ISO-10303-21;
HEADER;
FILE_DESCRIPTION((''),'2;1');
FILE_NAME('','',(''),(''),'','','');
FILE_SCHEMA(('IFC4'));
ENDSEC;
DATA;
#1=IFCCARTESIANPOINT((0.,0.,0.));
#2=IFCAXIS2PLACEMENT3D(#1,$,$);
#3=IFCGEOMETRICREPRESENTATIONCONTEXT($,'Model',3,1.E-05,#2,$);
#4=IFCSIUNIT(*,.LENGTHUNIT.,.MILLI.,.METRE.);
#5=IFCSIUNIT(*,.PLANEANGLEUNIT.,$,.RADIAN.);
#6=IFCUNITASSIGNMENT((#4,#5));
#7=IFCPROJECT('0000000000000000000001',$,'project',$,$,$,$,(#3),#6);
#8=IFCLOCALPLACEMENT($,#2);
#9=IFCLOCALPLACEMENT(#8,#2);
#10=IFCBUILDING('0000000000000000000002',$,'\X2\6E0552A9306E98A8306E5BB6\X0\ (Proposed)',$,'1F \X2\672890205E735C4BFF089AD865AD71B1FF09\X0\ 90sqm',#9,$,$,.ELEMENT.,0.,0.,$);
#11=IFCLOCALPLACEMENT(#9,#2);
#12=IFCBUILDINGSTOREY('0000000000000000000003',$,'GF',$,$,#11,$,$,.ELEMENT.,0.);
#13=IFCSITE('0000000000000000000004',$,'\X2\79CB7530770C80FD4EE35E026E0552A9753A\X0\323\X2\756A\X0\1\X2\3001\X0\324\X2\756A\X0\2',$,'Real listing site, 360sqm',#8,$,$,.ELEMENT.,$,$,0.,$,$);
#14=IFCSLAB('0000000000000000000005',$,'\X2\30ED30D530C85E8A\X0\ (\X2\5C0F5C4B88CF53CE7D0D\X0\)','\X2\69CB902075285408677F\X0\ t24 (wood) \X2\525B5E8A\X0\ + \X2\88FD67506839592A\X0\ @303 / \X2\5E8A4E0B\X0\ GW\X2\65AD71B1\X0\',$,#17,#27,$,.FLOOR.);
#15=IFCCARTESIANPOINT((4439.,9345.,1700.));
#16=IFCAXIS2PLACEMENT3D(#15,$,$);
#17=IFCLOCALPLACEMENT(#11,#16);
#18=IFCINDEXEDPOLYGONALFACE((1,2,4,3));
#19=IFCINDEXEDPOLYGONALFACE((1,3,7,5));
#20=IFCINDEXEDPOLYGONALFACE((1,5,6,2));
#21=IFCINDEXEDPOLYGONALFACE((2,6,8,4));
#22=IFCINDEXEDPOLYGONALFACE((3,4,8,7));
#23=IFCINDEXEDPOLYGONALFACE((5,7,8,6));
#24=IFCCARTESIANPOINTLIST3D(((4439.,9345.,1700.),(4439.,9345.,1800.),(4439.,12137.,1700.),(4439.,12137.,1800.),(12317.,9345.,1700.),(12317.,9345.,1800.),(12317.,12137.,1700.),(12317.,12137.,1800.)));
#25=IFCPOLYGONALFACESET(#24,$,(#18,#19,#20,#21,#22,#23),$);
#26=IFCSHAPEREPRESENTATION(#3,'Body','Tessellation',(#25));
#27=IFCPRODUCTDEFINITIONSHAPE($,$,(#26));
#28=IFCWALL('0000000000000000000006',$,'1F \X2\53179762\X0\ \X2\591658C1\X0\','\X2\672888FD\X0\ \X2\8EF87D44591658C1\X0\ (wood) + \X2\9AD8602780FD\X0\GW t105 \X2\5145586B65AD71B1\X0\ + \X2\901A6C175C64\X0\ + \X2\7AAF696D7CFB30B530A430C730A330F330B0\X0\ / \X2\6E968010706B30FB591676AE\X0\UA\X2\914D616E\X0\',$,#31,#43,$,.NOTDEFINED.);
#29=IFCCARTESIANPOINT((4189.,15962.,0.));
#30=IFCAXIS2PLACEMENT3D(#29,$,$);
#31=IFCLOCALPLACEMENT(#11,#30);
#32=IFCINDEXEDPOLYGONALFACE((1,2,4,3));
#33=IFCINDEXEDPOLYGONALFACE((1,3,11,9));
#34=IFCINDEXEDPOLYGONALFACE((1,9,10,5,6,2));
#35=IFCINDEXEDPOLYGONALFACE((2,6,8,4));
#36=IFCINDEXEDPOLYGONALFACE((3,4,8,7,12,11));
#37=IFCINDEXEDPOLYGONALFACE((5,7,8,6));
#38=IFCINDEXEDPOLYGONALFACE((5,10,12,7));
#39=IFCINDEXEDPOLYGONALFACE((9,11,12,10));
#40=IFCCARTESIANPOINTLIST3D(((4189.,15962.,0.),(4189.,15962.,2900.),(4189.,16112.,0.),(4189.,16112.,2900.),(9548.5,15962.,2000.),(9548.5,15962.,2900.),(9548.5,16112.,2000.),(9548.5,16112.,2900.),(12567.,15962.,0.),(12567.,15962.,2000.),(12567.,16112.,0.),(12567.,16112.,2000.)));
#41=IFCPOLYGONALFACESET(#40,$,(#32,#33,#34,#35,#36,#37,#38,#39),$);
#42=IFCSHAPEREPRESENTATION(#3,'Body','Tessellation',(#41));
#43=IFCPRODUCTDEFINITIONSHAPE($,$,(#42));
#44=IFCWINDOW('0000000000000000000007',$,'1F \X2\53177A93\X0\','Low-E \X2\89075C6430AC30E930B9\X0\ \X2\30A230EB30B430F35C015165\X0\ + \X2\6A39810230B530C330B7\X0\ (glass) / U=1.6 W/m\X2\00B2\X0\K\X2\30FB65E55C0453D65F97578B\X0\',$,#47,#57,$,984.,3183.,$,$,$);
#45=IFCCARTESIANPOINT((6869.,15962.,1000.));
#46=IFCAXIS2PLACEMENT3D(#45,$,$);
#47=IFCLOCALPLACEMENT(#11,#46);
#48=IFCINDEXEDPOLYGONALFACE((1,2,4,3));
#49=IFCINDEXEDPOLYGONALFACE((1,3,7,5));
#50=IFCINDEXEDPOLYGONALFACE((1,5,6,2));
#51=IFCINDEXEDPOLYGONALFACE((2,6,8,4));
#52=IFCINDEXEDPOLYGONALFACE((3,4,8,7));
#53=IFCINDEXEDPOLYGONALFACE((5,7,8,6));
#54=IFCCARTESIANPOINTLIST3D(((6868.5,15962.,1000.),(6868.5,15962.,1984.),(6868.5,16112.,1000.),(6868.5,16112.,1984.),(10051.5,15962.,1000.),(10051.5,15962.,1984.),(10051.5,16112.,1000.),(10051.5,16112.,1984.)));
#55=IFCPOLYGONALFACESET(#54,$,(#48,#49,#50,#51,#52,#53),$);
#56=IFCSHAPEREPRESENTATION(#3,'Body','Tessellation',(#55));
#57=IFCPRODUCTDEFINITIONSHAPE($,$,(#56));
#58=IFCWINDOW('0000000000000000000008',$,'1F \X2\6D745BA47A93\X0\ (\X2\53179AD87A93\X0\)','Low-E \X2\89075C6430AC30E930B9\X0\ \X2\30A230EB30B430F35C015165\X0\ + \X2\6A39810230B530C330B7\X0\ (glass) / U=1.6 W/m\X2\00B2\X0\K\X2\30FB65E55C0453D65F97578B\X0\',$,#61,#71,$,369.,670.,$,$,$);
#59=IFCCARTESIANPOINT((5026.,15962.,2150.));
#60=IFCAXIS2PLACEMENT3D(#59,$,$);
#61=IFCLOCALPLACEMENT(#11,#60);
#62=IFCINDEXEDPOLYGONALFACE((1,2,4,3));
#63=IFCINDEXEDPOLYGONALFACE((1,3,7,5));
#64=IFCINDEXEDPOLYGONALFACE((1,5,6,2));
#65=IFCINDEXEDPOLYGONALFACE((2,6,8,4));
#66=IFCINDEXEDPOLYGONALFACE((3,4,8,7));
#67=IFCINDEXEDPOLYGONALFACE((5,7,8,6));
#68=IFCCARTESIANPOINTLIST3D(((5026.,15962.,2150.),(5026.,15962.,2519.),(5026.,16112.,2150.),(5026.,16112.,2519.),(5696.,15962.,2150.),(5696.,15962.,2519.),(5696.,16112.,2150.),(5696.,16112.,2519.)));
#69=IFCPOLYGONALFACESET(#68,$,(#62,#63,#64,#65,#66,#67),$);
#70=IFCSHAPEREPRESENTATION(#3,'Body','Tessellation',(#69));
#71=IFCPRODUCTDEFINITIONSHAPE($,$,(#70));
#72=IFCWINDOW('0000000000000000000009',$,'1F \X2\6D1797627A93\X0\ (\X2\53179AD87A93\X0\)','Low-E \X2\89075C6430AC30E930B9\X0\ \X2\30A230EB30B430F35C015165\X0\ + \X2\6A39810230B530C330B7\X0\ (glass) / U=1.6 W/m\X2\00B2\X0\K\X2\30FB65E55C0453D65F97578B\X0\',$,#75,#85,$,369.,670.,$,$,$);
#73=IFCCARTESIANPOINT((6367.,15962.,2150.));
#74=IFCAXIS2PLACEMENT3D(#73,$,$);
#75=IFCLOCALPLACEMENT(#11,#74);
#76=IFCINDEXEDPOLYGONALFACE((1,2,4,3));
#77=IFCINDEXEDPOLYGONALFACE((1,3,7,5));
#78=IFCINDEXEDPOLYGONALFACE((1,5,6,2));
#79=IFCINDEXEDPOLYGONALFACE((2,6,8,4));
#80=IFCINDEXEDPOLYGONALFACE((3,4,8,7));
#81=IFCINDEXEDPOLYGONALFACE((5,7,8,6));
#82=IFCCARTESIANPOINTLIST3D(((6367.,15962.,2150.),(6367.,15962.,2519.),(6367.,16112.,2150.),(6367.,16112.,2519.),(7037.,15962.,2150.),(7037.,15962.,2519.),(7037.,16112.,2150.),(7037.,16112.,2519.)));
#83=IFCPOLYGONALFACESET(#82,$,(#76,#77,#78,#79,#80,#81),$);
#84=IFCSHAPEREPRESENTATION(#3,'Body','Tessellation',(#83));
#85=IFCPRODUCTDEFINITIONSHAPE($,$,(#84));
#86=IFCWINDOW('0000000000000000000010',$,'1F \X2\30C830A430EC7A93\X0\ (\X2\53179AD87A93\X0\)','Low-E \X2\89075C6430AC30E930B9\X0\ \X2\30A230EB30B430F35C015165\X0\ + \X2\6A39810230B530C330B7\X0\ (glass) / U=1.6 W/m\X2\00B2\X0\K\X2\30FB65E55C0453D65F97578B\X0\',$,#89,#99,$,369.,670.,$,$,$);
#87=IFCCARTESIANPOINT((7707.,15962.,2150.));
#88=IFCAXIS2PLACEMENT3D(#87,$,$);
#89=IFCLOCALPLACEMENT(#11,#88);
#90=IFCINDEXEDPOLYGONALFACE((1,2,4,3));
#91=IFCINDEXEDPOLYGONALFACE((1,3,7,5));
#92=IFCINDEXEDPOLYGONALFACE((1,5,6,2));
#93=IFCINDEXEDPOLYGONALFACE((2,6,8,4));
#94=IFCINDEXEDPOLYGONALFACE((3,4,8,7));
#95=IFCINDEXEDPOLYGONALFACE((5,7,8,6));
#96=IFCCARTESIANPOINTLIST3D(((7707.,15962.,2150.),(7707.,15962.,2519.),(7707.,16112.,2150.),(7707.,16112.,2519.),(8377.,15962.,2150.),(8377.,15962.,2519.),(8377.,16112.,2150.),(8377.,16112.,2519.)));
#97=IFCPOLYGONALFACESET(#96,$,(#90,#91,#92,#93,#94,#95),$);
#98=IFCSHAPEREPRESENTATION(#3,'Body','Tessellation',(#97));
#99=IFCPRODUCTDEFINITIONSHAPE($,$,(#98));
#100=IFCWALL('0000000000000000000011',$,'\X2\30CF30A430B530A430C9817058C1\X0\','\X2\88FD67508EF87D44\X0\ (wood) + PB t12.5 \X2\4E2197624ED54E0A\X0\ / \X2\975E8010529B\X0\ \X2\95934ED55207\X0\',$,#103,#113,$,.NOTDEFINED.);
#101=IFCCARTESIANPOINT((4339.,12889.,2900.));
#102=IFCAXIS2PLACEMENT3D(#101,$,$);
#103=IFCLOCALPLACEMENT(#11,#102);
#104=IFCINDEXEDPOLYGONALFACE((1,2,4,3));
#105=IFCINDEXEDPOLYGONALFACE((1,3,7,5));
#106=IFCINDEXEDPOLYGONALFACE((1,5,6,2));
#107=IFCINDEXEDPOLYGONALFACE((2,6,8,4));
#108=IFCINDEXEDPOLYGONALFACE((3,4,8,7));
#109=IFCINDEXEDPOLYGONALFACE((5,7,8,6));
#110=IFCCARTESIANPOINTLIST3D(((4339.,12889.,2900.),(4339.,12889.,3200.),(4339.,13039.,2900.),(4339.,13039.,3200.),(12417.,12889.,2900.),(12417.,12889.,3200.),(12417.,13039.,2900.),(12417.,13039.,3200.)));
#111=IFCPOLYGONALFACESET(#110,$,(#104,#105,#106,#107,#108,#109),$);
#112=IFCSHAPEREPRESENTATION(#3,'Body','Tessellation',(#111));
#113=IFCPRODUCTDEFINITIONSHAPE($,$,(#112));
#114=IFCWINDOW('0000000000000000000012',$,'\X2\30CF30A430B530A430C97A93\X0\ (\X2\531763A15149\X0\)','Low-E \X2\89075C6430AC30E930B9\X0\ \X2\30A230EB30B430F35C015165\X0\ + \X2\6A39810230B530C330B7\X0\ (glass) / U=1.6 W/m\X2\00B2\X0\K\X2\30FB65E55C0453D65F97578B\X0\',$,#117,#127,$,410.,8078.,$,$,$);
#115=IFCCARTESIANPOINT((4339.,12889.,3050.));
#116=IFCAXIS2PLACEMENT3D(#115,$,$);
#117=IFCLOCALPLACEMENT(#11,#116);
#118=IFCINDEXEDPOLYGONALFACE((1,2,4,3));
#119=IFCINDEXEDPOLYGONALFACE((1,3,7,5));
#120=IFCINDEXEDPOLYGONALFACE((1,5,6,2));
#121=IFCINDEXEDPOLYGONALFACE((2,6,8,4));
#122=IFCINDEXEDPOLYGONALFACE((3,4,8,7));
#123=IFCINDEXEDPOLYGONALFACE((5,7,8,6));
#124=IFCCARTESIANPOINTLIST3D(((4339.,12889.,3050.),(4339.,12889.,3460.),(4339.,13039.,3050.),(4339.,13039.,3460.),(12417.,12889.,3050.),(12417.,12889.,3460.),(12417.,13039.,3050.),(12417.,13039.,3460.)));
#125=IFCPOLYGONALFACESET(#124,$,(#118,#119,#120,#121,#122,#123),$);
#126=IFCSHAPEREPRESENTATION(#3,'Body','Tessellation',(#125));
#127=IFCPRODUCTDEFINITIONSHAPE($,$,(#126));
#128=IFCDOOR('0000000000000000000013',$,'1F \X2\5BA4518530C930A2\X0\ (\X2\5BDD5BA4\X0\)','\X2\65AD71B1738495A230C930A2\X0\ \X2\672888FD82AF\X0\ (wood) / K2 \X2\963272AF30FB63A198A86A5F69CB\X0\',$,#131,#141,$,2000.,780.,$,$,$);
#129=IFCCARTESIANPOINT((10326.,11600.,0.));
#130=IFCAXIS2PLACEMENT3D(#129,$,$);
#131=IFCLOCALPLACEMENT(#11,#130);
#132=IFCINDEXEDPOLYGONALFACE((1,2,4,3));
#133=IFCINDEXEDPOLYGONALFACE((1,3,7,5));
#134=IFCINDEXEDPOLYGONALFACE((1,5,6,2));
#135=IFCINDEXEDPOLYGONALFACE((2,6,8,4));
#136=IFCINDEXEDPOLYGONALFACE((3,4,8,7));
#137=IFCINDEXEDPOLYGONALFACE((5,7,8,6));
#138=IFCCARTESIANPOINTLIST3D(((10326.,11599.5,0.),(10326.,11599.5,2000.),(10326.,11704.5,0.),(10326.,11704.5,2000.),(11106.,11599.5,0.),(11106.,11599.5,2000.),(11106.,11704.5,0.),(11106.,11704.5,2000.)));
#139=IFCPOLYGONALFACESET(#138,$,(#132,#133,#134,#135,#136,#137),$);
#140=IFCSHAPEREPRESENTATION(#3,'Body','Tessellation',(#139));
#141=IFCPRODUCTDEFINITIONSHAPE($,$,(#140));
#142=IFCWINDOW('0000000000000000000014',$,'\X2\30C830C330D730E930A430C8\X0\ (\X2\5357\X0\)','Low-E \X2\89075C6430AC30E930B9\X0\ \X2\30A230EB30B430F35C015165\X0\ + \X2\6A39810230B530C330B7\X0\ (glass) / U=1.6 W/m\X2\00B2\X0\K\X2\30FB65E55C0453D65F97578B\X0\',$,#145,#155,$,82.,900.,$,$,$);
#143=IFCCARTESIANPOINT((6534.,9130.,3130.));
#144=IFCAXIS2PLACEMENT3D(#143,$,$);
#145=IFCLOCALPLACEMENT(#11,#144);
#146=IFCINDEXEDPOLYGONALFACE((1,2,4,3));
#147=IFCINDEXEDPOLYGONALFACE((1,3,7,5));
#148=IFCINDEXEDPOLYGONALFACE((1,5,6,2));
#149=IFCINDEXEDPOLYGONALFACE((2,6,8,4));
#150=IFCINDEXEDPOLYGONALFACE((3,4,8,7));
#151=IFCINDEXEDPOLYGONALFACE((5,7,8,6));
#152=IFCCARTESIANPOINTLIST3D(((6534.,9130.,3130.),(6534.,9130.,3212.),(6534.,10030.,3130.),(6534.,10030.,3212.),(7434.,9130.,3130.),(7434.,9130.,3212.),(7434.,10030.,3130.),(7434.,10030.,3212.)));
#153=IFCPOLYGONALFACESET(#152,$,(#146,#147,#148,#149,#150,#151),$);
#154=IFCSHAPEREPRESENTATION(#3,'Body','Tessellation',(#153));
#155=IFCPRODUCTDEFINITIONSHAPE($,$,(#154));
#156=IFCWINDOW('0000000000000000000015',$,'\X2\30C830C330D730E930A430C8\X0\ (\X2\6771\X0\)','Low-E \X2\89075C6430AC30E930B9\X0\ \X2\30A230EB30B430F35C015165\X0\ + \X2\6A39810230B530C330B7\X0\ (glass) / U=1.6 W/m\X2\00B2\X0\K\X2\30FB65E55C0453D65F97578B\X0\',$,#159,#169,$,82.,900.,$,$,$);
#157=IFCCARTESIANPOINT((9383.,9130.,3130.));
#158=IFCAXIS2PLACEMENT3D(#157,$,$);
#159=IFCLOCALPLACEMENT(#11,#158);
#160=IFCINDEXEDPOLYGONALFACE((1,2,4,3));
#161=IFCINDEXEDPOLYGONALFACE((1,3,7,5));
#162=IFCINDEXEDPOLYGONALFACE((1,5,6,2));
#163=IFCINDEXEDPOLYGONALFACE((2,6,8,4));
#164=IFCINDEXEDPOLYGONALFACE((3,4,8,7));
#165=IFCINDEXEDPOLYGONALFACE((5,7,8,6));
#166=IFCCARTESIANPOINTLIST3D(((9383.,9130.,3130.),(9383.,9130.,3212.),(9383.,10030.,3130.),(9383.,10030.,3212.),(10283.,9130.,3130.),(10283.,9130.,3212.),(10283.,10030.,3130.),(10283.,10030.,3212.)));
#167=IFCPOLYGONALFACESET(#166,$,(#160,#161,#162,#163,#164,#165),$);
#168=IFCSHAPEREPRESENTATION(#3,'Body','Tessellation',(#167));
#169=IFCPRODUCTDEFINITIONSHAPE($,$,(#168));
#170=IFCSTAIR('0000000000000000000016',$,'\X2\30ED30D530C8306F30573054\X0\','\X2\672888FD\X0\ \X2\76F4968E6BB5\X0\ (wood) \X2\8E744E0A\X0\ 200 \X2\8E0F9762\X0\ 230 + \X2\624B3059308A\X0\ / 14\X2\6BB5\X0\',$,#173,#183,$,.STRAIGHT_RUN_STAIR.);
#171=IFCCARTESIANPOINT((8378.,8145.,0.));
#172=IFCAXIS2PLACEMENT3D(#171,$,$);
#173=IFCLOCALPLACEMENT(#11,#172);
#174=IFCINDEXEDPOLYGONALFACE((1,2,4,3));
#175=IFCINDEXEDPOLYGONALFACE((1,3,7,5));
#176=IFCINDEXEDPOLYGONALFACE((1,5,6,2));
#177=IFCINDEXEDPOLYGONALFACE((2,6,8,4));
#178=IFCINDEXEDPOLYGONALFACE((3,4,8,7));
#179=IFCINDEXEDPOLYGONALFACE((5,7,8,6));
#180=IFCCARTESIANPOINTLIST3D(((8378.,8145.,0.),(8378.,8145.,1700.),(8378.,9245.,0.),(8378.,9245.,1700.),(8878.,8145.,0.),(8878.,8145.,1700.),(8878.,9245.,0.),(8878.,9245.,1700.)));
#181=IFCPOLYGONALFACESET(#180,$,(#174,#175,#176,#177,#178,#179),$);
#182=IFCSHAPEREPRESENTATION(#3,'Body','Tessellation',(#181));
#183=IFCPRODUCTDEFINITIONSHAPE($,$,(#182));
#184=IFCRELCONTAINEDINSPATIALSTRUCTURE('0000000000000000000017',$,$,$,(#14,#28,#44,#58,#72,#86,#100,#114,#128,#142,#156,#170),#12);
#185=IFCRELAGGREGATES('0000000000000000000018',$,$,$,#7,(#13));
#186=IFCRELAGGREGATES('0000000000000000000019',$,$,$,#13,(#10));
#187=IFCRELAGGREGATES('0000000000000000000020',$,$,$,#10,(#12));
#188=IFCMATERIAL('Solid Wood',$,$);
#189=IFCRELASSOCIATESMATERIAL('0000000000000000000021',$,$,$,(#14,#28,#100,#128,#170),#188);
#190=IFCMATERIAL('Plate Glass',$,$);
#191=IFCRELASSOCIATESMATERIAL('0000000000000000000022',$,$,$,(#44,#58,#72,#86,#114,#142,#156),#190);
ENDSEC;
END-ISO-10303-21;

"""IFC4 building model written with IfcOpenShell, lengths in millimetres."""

from ifc_helpers import new_model, si_unit, frame, frame_2d, origin, place, context, project, spatial, rectangle, extrude, material, element, fill, save


model = new_model("IFC4")

# Units and contexts
model_context = context("Model", 3, precision=1e-05, world=origin())
ifc_project = project(units=[si_unit("LENGTHUNIT", "METRE", prefix="MILLI"), si_unit("PLANEANGLEUNIT", "RADIAN")], contexts=[model_context])

# Site, building, storey
site_placement = place(None, origin())
site = spatial("IfcSite", under=ifc_project, at=site_placement, Name="秋田県能代市清助町323番1、324番2", ObjectType="Real listing site, 360sqm", CompositionType="ELEMENT", RefElevation=0.0)
building_placement = place(site_placement, origin())
building = spatial("IfcBuilding", under=site, at=building_placement, Name="清助の風の家 (Proposed)", ObjectType="1F 木造平屋（高断熱） 90sqm", CompositionType="ELEMENT", ElevationOfRefHeight=0.0, ElevationOfTerrain=0.0)
storey_placement = place(building_placement, origin())
storey = spatial("IfcBuildingStorey", under=building, at=storey_placement, Name="GF", CompositionType="ELEMENT", Elevation=0.0)

# Slab
ifc_material_1 = material(Name="Solid Wood")
slab_placement = place(storey_placement, frame((4439.0, 9345.0, 1700.0)))
element("IfcSlab", 1, at=slab_placement, inside=storey, material=ifc_material_1, Name="ロフト床 (小屋裏収納)", Description="構造用合板 t24 (wood) 剛床 + 製材根太 @303 / 床下 GW断熱", PredefinedType="FLOOR", context=model_context, shape_type="SweptSolid", body=[
    extrude(rectangle(XDim=7878.0, YDim=2792.0, at=frame_2d((3939.0, 1396.0))), frame((4439.0, 9345.0, 1700.0)), (0.0, 0.0, 1.0), 100.0),
])

# Wall, openings, windows
wall_1_placement = place(storey_placement, frame((4189.0, 15962.0, 0.0)))
wall_1 = element("IfcWall", 2, at=wall_1_placement, inside=storey, material=ifc_material_1, Name="1F 北面 外壁", Description="木製 軸組外壁 (wood) + 高性能GW t105 充填断熱 + 通気層 + 窯業系サイディング / 準耐火・外皮UA配慮", PredefinedType="NOTDEFINED", context=model_context, shape_type="SweptSolid", body=[
    extrude(rectangle(XDim=8378.0, YDim=150.0, at=frame_2d((4189.0, 75.0))), frame((4189.0, 15962.0, 0.0)), (0.0, 0.0, 1.0), 2900.0),
])
opening_1_placement = place(storey_placement, frame((6869.0, 15962.0, 1000.0)))
opening_1 = element("IfcOpeningElement", 3, at=opening_1_placement, cuts=wall_1, PredefinedType="NOTDEFINED", context=model_context, shape_type="SweptSolid", body=[
    extrude(rectangle(XDim=3183.0, YDim=150.0, at=frame_2d((1591.0, 75.0))), frame((6869.0, 15962.0, 1000.0)), (0.0, 0.0, 1.0), 984.0),
])
opening_2_placement = place(storey_placement, frame((5026.0, 15962.0, 2150.0)))
opening_2 = element("IfcOpeningElement", 4, at=opening_2_placement, cuts=wall_1, PredefinedType="NOTDEFINED", context=model_context, shape_type="SweptSolid", body=[
    extrude(rectangle(XDim=670.0, YDim=150.0, at=frame_2d((335.0, 75.0))), frame((5026.0, 15962.0, 2150.0)), (0.0, 0.0, 1.0), 369.0),
])
opening_3_placement = place(storey_placement, frame((6367.0, 15962.0, 2150.0)))
opening_3 = element("IfcOpeningElement", 5, at=opening_3_placement, cuts=wall_1, PredefinedType="NOTDEFINED", context=model_context, shape_type="SweptSolid", body=[
    extrude(rectangle(XDim=670.0, YDim=150.0, at=frame_2d((335.0, 75.0))), frame((6367.0, 15962.0, 2150.0)), (0.0, 0.0, 1.0), 369.0),
])
opening_4_placement = place(storey_placement, frame((7707.0, 15962.0, 2150.0)))
opening_4 = element("IfcOpeningElement", 6, at=opening_4_placement, cuts=wall_1, PredefinedType="NOTDEFINED", context=model_context, shape_type="SweptSolid", body=[
    extrude(rectangle(XDim=670.0, YDim=150.0, at=frame_2d((335.0, 75.0))), frame((7707.0, 15962.0, 2150.0)), (0.0, 0.0, 1.0), 369.0),
])
ifc_material_2 = material(Name="Plate Glass")
window_1_placement = place(storey_placement, frame((6869.0, 15962.0, 1000.0)))
window_1 = element("IfcWindow", 7, at=window_1_placement, inside=storey, material=ifc_material_2, Name="1F 北窓", Description="Low-E 複層ガラス アルゴン封入 + 樹脂サッシ (glass) / U=1.6 W/m²K・日射取得型", OverallHeight=984.0, OverallWidth=3183.0, context=model_context, shape_type="SweptSolid", body=[
    extrude(rectangle(XDim=3183.0, YDim=150.0, at=frame_2d((1591.0, 75.0))), frame((6869.0, 15962.0, 1000.0)), (0.0, 0.0, 1.0), 984.0),
])
fill(opening_1, window_1)
window_2_placement = place(storey_placement, frame((5026.0, 15962.0, 2150.0)))
window_2 = element("IfcWindow", 8, at=window_2_placement, inside=storey, material=ifc_material_2, Name="1F 浴室窓 (北高窓)", Description="Low-E 複層ガラス アルゴン封入 + 樹脂サッシ (glass) / U=1.6 W/m²K・日射取得型", OverallHeight=369.0, OverallWidth=670.0, context=model_context, shape_type="SweptSolid", body=[
    extrude(rectangle(XDim=670.0, YDim=150.0, at=frame_2d((335.0, 75.0))), frame((5026.0, 15962.0, 2150.0)), (0.0, 0.0, 1.0), 369.0),
])
fill(opening_2, window_2)
window_3_placement = place(storey_placement, frame((6367.0, 15962.0, 2150.0)))
window_3 = element("IfcWindow", 9, at=window_3_placement, inside=storey, material=ifc_material_2, Name="1F 洗面窓 (北高窓)", Description="Low-E 複層ガラス アルゴン封入 + 樹脂サッシ (glass) / U=1.6 W/m²K・日射取得型", OverallHeight=369.0, OverallWidth=670.0, context=model_context, shape_type="SweptSolid", body=[
    extrude(rectangle(XDim=670.0, YDim=150.0, at=frame_2d((335.0, 75.0))), frame((6367.0, 15962.0, 2150.0)), (0.0, 0.0, 1.0), 369.0),
])
fill(opening_3, window_3)
window_4_placement = place(storey_placement, frame((7707.0, 15962.0, 2150.0)))
window_4 = element("IfcWindow", 10, at=window_4_placement, inside=storey, material=ifc_material_2, Name="1F トイレ窓 (北高窓)", Description="Low-E 複層ガラス アルゴン封入 + 樹脂サッシ (glass) / U=1.6 W/m²K・日射取得型", OverallHeight=369.0, OverallWidth=670.0, context=model_context, shape_type="SweptSolid", body=[
    extrude(rectangle(XDim=670.0, YDim=150.0, at=frame_2d((335.0, 75.0))), frame((7707.0, 15962.0, 2150.0)), (0.0, 0.0, 1.0), 369.0),
])
fill(opening_4, window_4)

# Wall, opening, window
wall_2_placement = place(storey_placement, frame((4339.0, 12889.0, 2900.0)))
wall_2 = element("IfcWall", 11, at=wall_2_placement, inside=storey, material=ifc_material_1, Name="ハイサイド腰壁", Description="製材軸組 (wood) + PB t12.5 両面仕上 / 非耐力 間仕切", PredefinedType="NOTDEFINED", context=model_context, shape_type="SweptSolid", body=[
    extrude(rectangle(XDim=8078.0, YDim=150.0, at=frame_2d((4039.0, 75.0))), frame((4339.0, 12889.0, 2900.0)), (0.0, 0.0, 1.0), 700.0),
])
opening_5_placement = place(storey_placement, frame((4339.0, 12889.0, 3050.0)))
opening_5 = element("IfcOpeningElement", 12, at=opening_5_placement, cuts=wall_2, PredefinedType="NOTDEFINED", context=model_context, shape_type="SweptSolid", body=[
    extrude(rectangle(XDim=8078.0, YDim=150.0, at=frame_2d((4039.0, 75.0))), frame((4339.0, 12889.0, 3050.0)), (0.0, 0.0, 1.0), 410.0),
])
window_5_placement = place(storey_placement, frame((4339.0, 12889.0, 3050.0)))
window_5 = element("IfcWindow", 13, at=window_5_placement, inside=storey, material=ifc_material_2, Name="ハイサイド窓 (北採光)", Description="Low-E 複層ガラス アルゴン封入 + 樹脂サッシ (glass) / U=1.6 W/m²K・日射取得型", OverallHeight=410.0, OverallWidth=8078.0, context=model_context, shape_type="SweptSolid", body=[
    extrude(rectangle(XDim=8078.0, YDim=150.0, at=frame_2d((4039.0, 75.0))), frame((4339.0, 12889.0, 3050.0)), (0.0, 0.0, 1.0), 410.0),
])
fill(opening_5, window_5)

# Door
door_1_placement = place(storey_placement, frame((10326.0, 11600.0, 0.0)))
element("IfcDoor", 14, at=door_1_placement, inside=storey, material=ifc_material_1, Name="1F 室内ドア (寝室)", Description="断熱玄関ドア 木製芯 (wood) / K2 防犯・採風機構", OverallHeight=2000.0, OverallWidth=780.0, context=model_context, shape_type="SweptSolid", body=[
    extrude(rectangle(XDim=780.0, YDim=105.0, at=frame_2d((390.0, 52.0))), frame((10326.0, 11600.0, 0.0)), (0.0, 0.0, 1.0), 2000.0),
])

# Windows
window_6_placement = place(storey_placement, frame((6534.0, 9130.0, 3130.0)))
element("IfcWindow", 15, at=window_6_placement, inside=storey, material=ifc_material_2, Name="トップライト (南)", Description="Low-E 複層ガラス アルゴン封入 + 樹脂サッシ (glass) / U=1.6 W/m²K・日射取得型", OverallHeight=82.0, OverallWidth=900.0, context=model_context, shape_type="SweptSolid", body=[
    extrude(rectangle(XDim=900.0, YDim=900.0, at=frame_2d((450.0, 450.0))), frame((6534.0, 9130.0, 3130.0)), (0.0, 0.0, 1.0), 82.0),
])
window_7_placement = place(storey_placement, frame((9383.0, 9130.0, 3130.0)))
element("IfcWindow", 16, at=window_7_placement, inside=storey, material=ifc_material_2, Name="トップライト (東)", Description="Low-E 複層ガラス アルゴン封入 + 樹脂サッシ (glass) / U=1.6 W/m²K・日射取得型", OverallHeight=82.0, OverallWidth=900.0, context=model_context, shape_type="SweptSolid", body=[
    extrude(rectangle(XDim=900.0, YDim=900.0, at=frame_2d((450.0, 450.0))), frame((9383.0, 9130.0, 3130.0)), (0.0, 0.0, 1.0), 82.0),
])

# Stair
stair_placement = place(storey_placement, frame((8378.0, 8145.0, 0.0)))
element("IfcStair", 17, at=stair_placement, inside=storey, material=ifc_material_1, Name="ロフトはしご", Description="木製 直階段 (wood) 蹴上 200 踏面 230 + 手すり / 14段", PredefinedType="STRAIGHT_RUN_STAIR", context=model_context, shape_type="SweptSolid", body=[
    extrude(rectangle(XDim=500.0, YDim=1100.0, at=frame_2d((250.0, 550.0))), frame((8378.0, 8145.0, 0.0)), (0.0, 0.0, 1.0), 1700.0),
])

save(model, "model.ifc")
